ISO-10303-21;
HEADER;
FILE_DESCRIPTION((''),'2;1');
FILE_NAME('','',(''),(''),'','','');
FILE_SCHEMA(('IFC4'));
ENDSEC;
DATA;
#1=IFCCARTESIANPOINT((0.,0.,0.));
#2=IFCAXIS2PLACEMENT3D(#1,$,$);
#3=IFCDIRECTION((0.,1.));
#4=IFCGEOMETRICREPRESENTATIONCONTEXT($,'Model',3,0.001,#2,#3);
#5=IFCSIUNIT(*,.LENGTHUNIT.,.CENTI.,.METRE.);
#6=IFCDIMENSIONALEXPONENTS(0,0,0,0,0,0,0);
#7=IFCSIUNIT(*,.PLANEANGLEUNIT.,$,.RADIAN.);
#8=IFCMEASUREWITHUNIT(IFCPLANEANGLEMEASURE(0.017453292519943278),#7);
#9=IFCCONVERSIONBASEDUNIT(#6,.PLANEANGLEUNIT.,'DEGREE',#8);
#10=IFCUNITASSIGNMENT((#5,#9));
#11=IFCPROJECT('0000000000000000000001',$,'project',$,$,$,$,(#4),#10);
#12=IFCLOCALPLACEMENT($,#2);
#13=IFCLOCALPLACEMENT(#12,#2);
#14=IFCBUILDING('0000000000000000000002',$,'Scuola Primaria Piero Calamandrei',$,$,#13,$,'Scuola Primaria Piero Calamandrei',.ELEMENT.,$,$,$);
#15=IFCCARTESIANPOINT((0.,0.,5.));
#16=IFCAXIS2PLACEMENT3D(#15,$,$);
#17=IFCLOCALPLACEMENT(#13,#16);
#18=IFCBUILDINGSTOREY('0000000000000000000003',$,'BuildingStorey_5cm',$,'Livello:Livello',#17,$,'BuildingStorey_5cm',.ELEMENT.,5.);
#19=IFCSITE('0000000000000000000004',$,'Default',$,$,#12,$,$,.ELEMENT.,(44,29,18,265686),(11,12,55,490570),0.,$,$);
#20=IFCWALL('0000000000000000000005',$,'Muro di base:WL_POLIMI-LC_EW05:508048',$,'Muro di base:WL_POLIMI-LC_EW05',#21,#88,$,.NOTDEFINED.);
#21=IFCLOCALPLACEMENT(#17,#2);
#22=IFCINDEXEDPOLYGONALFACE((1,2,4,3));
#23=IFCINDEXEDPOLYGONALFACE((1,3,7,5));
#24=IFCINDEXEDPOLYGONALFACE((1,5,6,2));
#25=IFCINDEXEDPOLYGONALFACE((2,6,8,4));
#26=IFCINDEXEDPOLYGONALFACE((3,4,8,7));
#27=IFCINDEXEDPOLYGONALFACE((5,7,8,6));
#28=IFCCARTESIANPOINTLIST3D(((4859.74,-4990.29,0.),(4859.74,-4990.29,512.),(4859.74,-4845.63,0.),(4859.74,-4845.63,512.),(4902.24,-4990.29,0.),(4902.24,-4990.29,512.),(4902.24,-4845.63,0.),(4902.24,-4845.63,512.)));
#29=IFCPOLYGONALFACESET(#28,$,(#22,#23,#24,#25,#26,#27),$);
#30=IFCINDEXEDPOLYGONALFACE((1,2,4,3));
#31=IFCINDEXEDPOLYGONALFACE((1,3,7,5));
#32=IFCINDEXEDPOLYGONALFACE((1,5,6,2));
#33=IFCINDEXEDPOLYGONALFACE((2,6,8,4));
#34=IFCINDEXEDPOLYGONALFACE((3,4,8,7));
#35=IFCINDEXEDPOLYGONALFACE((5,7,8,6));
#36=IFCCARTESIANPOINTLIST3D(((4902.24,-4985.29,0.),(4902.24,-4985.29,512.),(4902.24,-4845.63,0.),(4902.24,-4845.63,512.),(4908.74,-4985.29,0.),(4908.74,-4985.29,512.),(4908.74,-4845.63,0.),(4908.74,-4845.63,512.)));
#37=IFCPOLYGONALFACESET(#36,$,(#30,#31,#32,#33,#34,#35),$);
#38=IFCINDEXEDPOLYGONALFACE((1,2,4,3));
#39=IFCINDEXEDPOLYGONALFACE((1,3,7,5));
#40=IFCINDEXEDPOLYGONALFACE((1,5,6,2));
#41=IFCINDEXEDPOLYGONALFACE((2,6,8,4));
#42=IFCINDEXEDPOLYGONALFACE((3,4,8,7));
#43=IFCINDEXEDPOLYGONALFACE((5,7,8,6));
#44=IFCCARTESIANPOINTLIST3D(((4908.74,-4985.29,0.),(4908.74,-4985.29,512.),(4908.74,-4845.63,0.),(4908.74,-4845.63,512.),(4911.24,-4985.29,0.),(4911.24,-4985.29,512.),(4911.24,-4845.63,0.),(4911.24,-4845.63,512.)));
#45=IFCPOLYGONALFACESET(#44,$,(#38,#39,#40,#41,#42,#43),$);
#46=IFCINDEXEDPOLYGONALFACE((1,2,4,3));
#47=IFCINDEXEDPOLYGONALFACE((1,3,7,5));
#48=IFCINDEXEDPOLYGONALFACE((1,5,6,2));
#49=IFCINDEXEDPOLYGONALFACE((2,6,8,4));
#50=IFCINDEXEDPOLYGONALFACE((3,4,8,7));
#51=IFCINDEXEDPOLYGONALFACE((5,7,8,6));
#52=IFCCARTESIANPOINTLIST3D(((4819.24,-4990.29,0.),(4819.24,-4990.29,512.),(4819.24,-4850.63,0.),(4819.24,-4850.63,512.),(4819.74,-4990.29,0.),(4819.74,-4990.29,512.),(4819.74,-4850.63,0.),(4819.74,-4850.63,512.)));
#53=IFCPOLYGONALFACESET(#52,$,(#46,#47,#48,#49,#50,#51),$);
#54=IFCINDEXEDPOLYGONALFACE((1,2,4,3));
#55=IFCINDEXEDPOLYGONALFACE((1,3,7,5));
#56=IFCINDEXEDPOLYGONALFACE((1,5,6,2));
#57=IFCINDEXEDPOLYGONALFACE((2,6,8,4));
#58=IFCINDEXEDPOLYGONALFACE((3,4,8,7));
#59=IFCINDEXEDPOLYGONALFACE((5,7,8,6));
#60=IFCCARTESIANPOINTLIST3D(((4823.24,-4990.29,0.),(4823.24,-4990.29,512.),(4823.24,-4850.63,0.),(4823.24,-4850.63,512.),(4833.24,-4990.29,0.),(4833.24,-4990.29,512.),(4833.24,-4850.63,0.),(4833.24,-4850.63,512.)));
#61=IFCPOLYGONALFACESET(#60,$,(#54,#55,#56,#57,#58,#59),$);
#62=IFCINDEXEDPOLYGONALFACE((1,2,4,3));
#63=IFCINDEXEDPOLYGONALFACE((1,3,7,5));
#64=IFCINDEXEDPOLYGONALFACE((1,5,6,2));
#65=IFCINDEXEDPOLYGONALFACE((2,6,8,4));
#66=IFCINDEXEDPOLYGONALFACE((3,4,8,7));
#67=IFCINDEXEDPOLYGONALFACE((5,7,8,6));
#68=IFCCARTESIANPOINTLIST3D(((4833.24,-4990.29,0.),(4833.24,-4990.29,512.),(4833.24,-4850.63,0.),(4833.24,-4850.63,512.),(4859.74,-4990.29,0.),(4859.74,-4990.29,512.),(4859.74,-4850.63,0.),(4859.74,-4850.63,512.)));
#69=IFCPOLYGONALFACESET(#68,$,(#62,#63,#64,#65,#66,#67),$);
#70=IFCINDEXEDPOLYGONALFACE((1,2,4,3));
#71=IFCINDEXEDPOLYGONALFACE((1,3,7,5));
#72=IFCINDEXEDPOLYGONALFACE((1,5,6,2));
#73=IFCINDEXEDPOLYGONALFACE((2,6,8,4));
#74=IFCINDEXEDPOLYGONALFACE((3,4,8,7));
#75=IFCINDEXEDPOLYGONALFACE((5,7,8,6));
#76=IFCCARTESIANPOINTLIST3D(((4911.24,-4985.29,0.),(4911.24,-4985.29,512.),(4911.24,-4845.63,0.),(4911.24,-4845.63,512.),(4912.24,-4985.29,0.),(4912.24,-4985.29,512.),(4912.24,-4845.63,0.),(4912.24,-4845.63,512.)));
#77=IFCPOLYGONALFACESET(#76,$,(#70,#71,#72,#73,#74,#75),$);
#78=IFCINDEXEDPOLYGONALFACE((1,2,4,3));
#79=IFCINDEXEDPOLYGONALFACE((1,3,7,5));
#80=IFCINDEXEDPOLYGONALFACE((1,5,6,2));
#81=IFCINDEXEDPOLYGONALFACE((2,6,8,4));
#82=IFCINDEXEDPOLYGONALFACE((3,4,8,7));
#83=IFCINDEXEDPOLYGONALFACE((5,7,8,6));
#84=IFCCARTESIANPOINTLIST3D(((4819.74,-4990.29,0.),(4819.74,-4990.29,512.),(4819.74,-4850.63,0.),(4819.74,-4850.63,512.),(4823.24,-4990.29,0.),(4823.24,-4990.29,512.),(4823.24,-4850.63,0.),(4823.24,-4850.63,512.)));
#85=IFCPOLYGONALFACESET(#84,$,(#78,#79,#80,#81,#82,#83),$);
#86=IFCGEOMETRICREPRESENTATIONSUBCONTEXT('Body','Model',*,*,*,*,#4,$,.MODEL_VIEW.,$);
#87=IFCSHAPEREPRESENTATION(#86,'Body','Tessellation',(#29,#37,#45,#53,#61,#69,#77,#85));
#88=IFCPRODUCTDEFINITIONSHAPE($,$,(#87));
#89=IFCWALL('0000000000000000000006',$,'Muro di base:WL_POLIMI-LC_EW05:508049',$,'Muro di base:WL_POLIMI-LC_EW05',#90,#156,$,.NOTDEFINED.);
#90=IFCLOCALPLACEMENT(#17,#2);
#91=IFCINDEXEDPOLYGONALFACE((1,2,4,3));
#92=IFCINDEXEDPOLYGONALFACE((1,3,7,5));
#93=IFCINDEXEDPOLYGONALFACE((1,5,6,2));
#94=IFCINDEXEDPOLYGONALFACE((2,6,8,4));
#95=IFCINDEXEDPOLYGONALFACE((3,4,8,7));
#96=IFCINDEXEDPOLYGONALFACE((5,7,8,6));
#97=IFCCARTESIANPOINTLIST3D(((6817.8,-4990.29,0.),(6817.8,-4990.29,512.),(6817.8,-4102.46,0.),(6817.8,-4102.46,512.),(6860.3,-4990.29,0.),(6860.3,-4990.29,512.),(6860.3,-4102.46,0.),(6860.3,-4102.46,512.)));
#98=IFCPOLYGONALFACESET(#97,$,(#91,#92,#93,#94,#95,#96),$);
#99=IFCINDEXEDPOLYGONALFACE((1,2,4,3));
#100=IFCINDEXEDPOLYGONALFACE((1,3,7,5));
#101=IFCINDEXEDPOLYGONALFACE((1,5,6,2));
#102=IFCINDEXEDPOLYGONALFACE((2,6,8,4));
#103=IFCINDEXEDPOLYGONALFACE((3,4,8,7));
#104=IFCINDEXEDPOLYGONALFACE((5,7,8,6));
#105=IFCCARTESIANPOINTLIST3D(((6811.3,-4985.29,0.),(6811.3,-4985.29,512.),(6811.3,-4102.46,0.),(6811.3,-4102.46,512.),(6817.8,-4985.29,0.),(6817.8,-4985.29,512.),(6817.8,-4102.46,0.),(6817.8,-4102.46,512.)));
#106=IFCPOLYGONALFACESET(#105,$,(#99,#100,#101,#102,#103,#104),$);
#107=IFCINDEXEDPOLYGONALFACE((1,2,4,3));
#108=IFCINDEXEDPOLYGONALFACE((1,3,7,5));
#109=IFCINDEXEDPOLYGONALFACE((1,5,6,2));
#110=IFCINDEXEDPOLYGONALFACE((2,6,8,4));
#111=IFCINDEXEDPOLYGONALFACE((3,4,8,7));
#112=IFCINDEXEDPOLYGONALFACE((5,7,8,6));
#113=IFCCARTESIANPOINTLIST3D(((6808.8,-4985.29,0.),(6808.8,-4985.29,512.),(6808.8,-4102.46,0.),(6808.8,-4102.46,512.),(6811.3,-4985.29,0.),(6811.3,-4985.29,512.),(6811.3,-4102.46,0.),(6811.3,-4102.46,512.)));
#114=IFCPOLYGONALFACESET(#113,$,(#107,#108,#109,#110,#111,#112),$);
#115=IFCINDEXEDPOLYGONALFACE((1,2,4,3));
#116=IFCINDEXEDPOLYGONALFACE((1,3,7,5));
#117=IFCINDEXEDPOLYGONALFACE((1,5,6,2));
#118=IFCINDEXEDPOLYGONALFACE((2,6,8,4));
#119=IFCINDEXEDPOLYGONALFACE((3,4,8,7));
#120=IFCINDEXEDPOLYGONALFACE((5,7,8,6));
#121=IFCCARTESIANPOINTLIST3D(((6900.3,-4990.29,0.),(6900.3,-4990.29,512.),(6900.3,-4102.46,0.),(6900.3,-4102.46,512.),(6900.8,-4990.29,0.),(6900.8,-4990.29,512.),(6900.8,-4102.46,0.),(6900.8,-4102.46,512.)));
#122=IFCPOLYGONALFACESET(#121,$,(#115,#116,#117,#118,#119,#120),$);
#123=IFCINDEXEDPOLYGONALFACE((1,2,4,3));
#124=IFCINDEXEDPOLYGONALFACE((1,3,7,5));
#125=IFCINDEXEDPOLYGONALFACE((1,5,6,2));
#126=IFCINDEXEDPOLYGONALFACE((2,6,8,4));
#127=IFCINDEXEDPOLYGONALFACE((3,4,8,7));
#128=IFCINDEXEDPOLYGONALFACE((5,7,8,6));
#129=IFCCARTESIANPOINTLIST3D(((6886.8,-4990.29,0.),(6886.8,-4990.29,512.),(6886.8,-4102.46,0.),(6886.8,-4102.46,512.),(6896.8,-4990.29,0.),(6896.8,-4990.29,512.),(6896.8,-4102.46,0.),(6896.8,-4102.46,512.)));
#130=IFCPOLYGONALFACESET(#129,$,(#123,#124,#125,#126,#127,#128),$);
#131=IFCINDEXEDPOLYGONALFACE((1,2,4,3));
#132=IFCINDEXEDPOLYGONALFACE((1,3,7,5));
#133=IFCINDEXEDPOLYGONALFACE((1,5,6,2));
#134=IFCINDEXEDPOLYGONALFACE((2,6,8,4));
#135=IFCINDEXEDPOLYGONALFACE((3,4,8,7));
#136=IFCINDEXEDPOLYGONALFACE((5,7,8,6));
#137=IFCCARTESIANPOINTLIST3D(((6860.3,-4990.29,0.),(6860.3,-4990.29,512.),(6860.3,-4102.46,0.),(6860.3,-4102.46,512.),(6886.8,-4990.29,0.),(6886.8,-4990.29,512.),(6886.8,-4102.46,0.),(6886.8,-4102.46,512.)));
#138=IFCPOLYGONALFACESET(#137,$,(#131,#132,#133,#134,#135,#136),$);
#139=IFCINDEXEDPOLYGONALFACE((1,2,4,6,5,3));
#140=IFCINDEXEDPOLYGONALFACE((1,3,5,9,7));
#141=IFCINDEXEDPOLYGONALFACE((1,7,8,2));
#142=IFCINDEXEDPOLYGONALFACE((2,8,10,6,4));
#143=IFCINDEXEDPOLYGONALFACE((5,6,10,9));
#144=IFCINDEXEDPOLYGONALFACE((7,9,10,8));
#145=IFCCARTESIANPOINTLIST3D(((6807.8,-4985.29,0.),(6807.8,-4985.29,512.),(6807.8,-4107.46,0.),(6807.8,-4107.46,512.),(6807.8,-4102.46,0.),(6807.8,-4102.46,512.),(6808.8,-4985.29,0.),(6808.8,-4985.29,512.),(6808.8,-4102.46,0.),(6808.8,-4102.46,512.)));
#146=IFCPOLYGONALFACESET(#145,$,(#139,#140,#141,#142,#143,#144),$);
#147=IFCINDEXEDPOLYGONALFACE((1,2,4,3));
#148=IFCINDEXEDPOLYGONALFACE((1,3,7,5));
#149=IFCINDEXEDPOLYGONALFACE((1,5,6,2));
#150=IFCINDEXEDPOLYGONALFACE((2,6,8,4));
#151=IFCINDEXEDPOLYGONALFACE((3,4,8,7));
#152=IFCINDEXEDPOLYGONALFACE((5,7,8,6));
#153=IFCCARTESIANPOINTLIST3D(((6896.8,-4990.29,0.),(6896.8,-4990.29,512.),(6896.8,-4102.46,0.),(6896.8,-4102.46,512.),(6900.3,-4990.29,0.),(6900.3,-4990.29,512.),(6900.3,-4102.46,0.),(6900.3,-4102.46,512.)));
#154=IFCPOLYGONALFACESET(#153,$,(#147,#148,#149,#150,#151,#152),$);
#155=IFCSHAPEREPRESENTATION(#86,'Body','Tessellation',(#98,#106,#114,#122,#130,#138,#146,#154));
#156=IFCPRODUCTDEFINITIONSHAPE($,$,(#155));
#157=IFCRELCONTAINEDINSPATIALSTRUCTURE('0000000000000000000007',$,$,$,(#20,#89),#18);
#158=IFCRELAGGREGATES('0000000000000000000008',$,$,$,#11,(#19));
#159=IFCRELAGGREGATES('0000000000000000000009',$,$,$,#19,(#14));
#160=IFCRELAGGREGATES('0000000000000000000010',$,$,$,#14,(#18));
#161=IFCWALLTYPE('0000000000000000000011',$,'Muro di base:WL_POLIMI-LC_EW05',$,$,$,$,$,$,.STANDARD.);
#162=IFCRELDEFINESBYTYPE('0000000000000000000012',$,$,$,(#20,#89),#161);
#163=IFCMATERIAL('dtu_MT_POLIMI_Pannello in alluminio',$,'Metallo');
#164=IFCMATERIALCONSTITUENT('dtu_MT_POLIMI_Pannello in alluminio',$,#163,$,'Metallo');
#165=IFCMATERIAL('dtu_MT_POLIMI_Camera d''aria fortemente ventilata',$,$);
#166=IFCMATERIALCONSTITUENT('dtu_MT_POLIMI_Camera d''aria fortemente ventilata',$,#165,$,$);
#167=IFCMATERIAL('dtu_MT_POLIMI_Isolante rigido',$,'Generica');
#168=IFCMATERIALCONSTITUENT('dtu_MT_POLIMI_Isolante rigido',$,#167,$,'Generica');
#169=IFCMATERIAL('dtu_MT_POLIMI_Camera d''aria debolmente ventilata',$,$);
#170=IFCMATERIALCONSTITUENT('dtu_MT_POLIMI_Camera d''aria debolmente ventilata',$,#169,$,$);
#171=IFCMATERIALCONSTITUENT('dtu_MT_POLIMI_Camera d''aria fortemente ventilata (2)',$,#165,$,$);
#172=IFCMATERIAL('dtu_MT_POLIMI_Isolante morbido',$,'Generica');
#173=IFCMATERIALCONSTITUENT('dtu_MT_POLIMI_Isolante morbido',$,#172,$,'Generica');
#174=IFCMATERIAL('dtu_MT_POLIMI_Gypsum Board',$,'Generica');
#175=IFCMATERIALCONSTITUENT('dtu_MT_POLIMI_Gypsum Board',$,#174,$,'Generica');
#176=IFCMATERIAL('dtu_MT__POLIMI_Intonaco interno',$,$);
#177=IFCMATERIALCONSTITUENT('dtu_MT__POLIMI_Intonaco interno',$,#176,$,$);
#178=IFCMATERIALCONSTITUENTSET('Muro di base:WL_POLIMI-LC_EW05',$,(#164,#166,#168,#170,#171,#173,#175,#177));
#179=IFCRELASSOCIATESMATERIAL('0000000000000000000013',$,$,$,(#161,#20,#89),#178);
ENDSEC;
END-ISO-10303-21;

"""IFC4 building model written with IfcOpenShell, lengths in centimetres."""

from ifc_helpers import new_model, entity, si_unit, converted_unit, direction, frame, origin, place, context, subcontext, project, spatial, indexed_curve, outline, extrude, material, constituent, constituent_set, type_object, element, save


model = new_model("IFC4")

# Units and contexts
model_context = context("Model", 3, precision=0.001, world=origin(), true_north=direction((0.0, 1.0)))
body_context = subcontext(model_context, "Body", "Model", "MODEL_VIEW")
ifc_project = project(units=[si_unit("LENGTHUNIT", "METRE", prefix="CENTI"), converted_unit("PLANEANGLEUNIT", "DEGREE", entity("IfcPlaneAngleMeasure", 0.017453292519943278), si_unit("PLANEANGLEUNIT", "RADIAN"), dimensions=[0, 0, 0, 0, 0, 0, 0])], contexts=[model_context])

# Site, building, storey
site_placement = place(None, origin())
site = spatial("IfcSite", under=ifc_project, at=site_placement, Name="Default", CompositionType="ELEMENT", RefLatitude=(44, 29, 18, 265686), RefLongitude=(11, 12, 55, 490570), RefElevation=0.0)
building_placement = place(site_placement, origin())
building = spatial("IfcBuilding", under=site, at=building_placement, Name="Scuola Primaria Piero Calamandrei", LongName="Scuola Primaria Piero Calamandrei", CompositionType="ELEMENT")
storey_placement = place(building_placement, frame((0.0, 0.0, 5.0)))
storey = spatial("IfcBuildingStorey", under=building, at=storey_placement, Name="BuildingStorey_5cm", ObjectType="Livello:Livello", LongName="BuildingStorey_5cm", CompositionType="ELEMENT", Elevation=5.0)

# Walls
ifc_material_1 = material(Name="dtu_MT_POLIMI_Pannello in alluminio", Category="Metallo")
ifc_constituent_1 = constituent(ifc_material_1, Name="dtu_MT_POLIMI_Pannello in alluminio", Category="Metallo")
ifc_material_2 = material(Name="dtu_MT_POLIMI_Camera d'aria fortemente ventilata")
ifc_constituent_2 = constituent(ifc_material_2, Name="dtu_MT_POLIMI_Camera d'aria fortemente ventilata")
ifc_material_3 = material(Name="dtu_MT_POLIMI_Isolante rigido", Category="Generica")
ifc_constituent_3 = constituent(ifc_material_3, Name="dtu_MT_POLIMI_Isolante rigido", Category="Generica")
ifc_material_4 = material(Name="dtu_MT_POLIMI_Camera d'aria debolmente ventilata")
ifc_constituent_4 = constituent(ifc_material_4, Name="dtu_MT_POLIMI_Camera d'aria debolmente ventilata")
ifc_constituent_5 = constituent(ifc_material_2, Name="dtu_MT_POLIMI_Camera d'aria fortemente ventilata (2)")
ifc_material_5 = material(Name="dtu_MT_POLIMI_Isolante morbido", Category="Generica")
ifc_constituent_6 = constituent(ifc_material_5, Name="dtu_MT_POLIMI_Isolante morbido", Category="Generica")
ifc_material_6 = material(Name="dtu_MT_POLIMI_Gypsum Board", Category="Generica")
ifc_constituent_7 = constituent(ifc_material_6, Name="dtu_MT_POLIMI_Gypsum Board", Category="Generica")
ifc_material_7 = material(Name="dtu_MT__POLIMI_Intonaco interno")
ifc_constituent_8 = constituent(ifc_material_7, Name="dtu_MT__POLIMI_Intonaco interno")
ifc_constituent_set_1 = constituent_set(constituents=[ifc_constituent_1, ifc_constituent_2, ifc_constituent_3, ifc_constituent_4, ifc_constituent_5, ifc_constituent_6, ifc_constituent_7, ifc_constituent_8], Name="Muro di base:WL_POLIMI-LC_EW05")
wall_type_1 = type_object("IfcWallType", Name="Muro di base:WL_POLIMI-LC_EW05", PredefinedType="STANDARD", material=ifc_constituent_set_1)
wall_1_placement = place(storey_placement, frame((4865.74, -4990.29, 0.0), z_axis=(0.0, 0.0, 1.0), x_axis=(0.0, 1.0, 0.0)))
element("IfcWall", 1, at=wall_1_placement, inside=storey, type_object=wall_type_1, material=ifc_constituent_set_1, Name="Muro di base:WL_POLIMI-LC_EW05:508048", ObjectType="Muro di base:WL_POLIMI-LC_EW05", PredefinedType="NOTDEFINED", context=body_context, shape_type="SweptSolid", body=[
    extrude(outline(indexed_curve([(-72.33, -21.25), (72.33, -21.25), (72.33, 21.25), (-72.33, 21.25), (-72.33, -21.25)], self_intersect=False)), frame((72.33, -15.25, 0.0)), (0.0, 0.0, 1.0), 512.0),
    extrude(outline(indexed_curve([(-69.83, -3.25), (69.83, -3.25), (69.83, 3.25), (-69.83, 3.25), (-69.83, -3.25)], self_intersect=False)), frame((74.83, -39.75, 0.0)), (0.0, 0.0, 1.0), 512.0),
    extrude(outline(indexed_curve([(-69.83, -1.25), (69.83, -1.25), (69.83, 1.25), (-69.83, 1.25), (-69.83, -1.25)], self_intersect=False)), frame((74.83, -44.25, 0.0)), (0.0, 0.0, 1.0), 512.0),
    extrude(outline(indexed_curve([(-69.83, -0.25), (69.83, -0.25), (69.83, 0.25), (-69.83, 0.25), (-69.83, -0.25)], self_intersect=False)), frame((69.83, 46.25, 0.0), z_axis=(0.0, 0.0, 1.0), x_axis=(-1.0, 0.0, 0.0)), (0.0, 0.0, 1.0), 512.0),
    extrude(outline(indexed_curve([(-69.83, -5.0), (69.83, -5.0), (69.83, 5.0), (-69.83, 5.0), (-69.83, -5.0)], self_intersect=False)), frame((69.83, 37.5, 0.0)), (0.0, 0.0, 1.0), 512.0),
    extrude(outline(indexed_curve([(-69.83, -13.25), (69.83, -13.25), (69.83, 13.25), (-69.83, 13.25), (-69.83, -13.25)], self_intersect=False)), frame((69.83, 19.25, 0.0)), (0.0, 0.0, 1.0), 512.0),
    extrude(outline(indexed_curve([(-69.83, -0.5), (69.83, -0.5), (69.83, 0.5), (-69.83, 0.5), (-69.83, -0.5)], self_intersect=False)), frame((74.83, -46.0, 0.0)), (0.0, 0.0, 1.0), 512.0),
    extrude(outline(indexed_curve([(-69.83, -1.75), (69.83, -1.75), (69.83, 1.75), (-69.83, 1.75), (-69.83, -1.75)], self_intersect=False)), frame((69.83, 44.25, 0.0)), (0.0, 0.0, 1.0), 512.0),
])
wall_2_placement = place(storey_placement, frame((6854.3, -4102.46, 0.0), z_axis=(0.0, 0.0, 1.0), x_axis=(0.0, -1.0, 0.0)))
element("IfcWall", 2, at=wall_2_placement, inside=storey, type_object=wall_type_1, material=ifc_constituent_set_1, Name="Muro di base:WL_POLIMI-LC_EW05:508049", ObjectType="Muro di base:WL_POLIMI-LC_EW05", PredefinedType="NOTDEFINED", context=body_context, shape_type="SweptSolid", body=[
    extrude(outline(indexed_curve([(-443.91, -21.25), (443.91, -21.25), (443.91, 21.25), (-443.91, 21.25), (-443.91, -21.25)], self_intersect=False)), frame((443.91, -15.25, 0.0)), (0.0, 0.0, 1.0), 512.0),
    extrude(outline(indexed_curve([(-441.41, -3.25), (441.41, -3.25), (441.41, 3.25), (-441.41, 3.25), (-441.41, -3.25)], self_intersect=False)), frame((441.41, -39.75, 0.0)), (0.0, 0.0, 1.0), 512.0),
    extrude(outline(indexed_curve([(-441.41, -1.25), (441.41, -1.25), (441.41, 1.25), (-441.41, 1.25), (-441.41, -1.25)], self_intersect=False)), frame((441.41, -44.25, 0.0)), (0.0, 0.0, 1.0), 512.0),
    extrude(outline(indexed_curve([(-0.25, -443.91), (0.25, -443.91), (0.25, 443.91), (-0.25, 443.91), (-0.25, -443.91)], self_intersect=False)), frame((443.91, 46.25, 0.0), z_axis=(0.0, 0.0, 1.0), x_axis=(0.0, -1.0, 0.0)), (0.0, 0.0, 1.0), 512.0),
    extrude(outline(indexed_curve([(-443.91, -5.0), (443.91, -5.0), (443.91, 5.0), (-443.91, 5.0), (-443.91, -5.0)], self_intersect=False)), frame((443.91, 37.5, 0.0)), (0.0, 0.0, 1.0), 512.0),
    extrude(outline(indexed_curve([(-443.91, -13.25), (443.91, -13.25), (443.91, 13.25), (-443.91, 13.25), (-443.91, -13.25)], self_intersect=False)), frame((443.91, 19.25, 0.0)), (0.0, 0.0, 1.0), 512.0),
    extrude(outline(indexed_curve([(-349.13, -0.4), (528.69, -0.4), (528.69, 0.6), (-354.13, 0.6), (-354.13, -0.4), (-349.13, -0.4)], self_intersect=False)), frame((354.13, -46.1, 0.0)), (0.0, 0.0, 1.0), 512.0),
    extrude(outline(indexed_curve([(-443.91, -1.75), (443.91, -1.75), (443.91, 1.75), (-443.91, 1.75), (-443.91, -1.75)], self_intersect=False)), frame((443.91, 44.25, 0.0)), (0.0, 0.0, 1.0), 512.0),
])

save(model, "model.ifc")
